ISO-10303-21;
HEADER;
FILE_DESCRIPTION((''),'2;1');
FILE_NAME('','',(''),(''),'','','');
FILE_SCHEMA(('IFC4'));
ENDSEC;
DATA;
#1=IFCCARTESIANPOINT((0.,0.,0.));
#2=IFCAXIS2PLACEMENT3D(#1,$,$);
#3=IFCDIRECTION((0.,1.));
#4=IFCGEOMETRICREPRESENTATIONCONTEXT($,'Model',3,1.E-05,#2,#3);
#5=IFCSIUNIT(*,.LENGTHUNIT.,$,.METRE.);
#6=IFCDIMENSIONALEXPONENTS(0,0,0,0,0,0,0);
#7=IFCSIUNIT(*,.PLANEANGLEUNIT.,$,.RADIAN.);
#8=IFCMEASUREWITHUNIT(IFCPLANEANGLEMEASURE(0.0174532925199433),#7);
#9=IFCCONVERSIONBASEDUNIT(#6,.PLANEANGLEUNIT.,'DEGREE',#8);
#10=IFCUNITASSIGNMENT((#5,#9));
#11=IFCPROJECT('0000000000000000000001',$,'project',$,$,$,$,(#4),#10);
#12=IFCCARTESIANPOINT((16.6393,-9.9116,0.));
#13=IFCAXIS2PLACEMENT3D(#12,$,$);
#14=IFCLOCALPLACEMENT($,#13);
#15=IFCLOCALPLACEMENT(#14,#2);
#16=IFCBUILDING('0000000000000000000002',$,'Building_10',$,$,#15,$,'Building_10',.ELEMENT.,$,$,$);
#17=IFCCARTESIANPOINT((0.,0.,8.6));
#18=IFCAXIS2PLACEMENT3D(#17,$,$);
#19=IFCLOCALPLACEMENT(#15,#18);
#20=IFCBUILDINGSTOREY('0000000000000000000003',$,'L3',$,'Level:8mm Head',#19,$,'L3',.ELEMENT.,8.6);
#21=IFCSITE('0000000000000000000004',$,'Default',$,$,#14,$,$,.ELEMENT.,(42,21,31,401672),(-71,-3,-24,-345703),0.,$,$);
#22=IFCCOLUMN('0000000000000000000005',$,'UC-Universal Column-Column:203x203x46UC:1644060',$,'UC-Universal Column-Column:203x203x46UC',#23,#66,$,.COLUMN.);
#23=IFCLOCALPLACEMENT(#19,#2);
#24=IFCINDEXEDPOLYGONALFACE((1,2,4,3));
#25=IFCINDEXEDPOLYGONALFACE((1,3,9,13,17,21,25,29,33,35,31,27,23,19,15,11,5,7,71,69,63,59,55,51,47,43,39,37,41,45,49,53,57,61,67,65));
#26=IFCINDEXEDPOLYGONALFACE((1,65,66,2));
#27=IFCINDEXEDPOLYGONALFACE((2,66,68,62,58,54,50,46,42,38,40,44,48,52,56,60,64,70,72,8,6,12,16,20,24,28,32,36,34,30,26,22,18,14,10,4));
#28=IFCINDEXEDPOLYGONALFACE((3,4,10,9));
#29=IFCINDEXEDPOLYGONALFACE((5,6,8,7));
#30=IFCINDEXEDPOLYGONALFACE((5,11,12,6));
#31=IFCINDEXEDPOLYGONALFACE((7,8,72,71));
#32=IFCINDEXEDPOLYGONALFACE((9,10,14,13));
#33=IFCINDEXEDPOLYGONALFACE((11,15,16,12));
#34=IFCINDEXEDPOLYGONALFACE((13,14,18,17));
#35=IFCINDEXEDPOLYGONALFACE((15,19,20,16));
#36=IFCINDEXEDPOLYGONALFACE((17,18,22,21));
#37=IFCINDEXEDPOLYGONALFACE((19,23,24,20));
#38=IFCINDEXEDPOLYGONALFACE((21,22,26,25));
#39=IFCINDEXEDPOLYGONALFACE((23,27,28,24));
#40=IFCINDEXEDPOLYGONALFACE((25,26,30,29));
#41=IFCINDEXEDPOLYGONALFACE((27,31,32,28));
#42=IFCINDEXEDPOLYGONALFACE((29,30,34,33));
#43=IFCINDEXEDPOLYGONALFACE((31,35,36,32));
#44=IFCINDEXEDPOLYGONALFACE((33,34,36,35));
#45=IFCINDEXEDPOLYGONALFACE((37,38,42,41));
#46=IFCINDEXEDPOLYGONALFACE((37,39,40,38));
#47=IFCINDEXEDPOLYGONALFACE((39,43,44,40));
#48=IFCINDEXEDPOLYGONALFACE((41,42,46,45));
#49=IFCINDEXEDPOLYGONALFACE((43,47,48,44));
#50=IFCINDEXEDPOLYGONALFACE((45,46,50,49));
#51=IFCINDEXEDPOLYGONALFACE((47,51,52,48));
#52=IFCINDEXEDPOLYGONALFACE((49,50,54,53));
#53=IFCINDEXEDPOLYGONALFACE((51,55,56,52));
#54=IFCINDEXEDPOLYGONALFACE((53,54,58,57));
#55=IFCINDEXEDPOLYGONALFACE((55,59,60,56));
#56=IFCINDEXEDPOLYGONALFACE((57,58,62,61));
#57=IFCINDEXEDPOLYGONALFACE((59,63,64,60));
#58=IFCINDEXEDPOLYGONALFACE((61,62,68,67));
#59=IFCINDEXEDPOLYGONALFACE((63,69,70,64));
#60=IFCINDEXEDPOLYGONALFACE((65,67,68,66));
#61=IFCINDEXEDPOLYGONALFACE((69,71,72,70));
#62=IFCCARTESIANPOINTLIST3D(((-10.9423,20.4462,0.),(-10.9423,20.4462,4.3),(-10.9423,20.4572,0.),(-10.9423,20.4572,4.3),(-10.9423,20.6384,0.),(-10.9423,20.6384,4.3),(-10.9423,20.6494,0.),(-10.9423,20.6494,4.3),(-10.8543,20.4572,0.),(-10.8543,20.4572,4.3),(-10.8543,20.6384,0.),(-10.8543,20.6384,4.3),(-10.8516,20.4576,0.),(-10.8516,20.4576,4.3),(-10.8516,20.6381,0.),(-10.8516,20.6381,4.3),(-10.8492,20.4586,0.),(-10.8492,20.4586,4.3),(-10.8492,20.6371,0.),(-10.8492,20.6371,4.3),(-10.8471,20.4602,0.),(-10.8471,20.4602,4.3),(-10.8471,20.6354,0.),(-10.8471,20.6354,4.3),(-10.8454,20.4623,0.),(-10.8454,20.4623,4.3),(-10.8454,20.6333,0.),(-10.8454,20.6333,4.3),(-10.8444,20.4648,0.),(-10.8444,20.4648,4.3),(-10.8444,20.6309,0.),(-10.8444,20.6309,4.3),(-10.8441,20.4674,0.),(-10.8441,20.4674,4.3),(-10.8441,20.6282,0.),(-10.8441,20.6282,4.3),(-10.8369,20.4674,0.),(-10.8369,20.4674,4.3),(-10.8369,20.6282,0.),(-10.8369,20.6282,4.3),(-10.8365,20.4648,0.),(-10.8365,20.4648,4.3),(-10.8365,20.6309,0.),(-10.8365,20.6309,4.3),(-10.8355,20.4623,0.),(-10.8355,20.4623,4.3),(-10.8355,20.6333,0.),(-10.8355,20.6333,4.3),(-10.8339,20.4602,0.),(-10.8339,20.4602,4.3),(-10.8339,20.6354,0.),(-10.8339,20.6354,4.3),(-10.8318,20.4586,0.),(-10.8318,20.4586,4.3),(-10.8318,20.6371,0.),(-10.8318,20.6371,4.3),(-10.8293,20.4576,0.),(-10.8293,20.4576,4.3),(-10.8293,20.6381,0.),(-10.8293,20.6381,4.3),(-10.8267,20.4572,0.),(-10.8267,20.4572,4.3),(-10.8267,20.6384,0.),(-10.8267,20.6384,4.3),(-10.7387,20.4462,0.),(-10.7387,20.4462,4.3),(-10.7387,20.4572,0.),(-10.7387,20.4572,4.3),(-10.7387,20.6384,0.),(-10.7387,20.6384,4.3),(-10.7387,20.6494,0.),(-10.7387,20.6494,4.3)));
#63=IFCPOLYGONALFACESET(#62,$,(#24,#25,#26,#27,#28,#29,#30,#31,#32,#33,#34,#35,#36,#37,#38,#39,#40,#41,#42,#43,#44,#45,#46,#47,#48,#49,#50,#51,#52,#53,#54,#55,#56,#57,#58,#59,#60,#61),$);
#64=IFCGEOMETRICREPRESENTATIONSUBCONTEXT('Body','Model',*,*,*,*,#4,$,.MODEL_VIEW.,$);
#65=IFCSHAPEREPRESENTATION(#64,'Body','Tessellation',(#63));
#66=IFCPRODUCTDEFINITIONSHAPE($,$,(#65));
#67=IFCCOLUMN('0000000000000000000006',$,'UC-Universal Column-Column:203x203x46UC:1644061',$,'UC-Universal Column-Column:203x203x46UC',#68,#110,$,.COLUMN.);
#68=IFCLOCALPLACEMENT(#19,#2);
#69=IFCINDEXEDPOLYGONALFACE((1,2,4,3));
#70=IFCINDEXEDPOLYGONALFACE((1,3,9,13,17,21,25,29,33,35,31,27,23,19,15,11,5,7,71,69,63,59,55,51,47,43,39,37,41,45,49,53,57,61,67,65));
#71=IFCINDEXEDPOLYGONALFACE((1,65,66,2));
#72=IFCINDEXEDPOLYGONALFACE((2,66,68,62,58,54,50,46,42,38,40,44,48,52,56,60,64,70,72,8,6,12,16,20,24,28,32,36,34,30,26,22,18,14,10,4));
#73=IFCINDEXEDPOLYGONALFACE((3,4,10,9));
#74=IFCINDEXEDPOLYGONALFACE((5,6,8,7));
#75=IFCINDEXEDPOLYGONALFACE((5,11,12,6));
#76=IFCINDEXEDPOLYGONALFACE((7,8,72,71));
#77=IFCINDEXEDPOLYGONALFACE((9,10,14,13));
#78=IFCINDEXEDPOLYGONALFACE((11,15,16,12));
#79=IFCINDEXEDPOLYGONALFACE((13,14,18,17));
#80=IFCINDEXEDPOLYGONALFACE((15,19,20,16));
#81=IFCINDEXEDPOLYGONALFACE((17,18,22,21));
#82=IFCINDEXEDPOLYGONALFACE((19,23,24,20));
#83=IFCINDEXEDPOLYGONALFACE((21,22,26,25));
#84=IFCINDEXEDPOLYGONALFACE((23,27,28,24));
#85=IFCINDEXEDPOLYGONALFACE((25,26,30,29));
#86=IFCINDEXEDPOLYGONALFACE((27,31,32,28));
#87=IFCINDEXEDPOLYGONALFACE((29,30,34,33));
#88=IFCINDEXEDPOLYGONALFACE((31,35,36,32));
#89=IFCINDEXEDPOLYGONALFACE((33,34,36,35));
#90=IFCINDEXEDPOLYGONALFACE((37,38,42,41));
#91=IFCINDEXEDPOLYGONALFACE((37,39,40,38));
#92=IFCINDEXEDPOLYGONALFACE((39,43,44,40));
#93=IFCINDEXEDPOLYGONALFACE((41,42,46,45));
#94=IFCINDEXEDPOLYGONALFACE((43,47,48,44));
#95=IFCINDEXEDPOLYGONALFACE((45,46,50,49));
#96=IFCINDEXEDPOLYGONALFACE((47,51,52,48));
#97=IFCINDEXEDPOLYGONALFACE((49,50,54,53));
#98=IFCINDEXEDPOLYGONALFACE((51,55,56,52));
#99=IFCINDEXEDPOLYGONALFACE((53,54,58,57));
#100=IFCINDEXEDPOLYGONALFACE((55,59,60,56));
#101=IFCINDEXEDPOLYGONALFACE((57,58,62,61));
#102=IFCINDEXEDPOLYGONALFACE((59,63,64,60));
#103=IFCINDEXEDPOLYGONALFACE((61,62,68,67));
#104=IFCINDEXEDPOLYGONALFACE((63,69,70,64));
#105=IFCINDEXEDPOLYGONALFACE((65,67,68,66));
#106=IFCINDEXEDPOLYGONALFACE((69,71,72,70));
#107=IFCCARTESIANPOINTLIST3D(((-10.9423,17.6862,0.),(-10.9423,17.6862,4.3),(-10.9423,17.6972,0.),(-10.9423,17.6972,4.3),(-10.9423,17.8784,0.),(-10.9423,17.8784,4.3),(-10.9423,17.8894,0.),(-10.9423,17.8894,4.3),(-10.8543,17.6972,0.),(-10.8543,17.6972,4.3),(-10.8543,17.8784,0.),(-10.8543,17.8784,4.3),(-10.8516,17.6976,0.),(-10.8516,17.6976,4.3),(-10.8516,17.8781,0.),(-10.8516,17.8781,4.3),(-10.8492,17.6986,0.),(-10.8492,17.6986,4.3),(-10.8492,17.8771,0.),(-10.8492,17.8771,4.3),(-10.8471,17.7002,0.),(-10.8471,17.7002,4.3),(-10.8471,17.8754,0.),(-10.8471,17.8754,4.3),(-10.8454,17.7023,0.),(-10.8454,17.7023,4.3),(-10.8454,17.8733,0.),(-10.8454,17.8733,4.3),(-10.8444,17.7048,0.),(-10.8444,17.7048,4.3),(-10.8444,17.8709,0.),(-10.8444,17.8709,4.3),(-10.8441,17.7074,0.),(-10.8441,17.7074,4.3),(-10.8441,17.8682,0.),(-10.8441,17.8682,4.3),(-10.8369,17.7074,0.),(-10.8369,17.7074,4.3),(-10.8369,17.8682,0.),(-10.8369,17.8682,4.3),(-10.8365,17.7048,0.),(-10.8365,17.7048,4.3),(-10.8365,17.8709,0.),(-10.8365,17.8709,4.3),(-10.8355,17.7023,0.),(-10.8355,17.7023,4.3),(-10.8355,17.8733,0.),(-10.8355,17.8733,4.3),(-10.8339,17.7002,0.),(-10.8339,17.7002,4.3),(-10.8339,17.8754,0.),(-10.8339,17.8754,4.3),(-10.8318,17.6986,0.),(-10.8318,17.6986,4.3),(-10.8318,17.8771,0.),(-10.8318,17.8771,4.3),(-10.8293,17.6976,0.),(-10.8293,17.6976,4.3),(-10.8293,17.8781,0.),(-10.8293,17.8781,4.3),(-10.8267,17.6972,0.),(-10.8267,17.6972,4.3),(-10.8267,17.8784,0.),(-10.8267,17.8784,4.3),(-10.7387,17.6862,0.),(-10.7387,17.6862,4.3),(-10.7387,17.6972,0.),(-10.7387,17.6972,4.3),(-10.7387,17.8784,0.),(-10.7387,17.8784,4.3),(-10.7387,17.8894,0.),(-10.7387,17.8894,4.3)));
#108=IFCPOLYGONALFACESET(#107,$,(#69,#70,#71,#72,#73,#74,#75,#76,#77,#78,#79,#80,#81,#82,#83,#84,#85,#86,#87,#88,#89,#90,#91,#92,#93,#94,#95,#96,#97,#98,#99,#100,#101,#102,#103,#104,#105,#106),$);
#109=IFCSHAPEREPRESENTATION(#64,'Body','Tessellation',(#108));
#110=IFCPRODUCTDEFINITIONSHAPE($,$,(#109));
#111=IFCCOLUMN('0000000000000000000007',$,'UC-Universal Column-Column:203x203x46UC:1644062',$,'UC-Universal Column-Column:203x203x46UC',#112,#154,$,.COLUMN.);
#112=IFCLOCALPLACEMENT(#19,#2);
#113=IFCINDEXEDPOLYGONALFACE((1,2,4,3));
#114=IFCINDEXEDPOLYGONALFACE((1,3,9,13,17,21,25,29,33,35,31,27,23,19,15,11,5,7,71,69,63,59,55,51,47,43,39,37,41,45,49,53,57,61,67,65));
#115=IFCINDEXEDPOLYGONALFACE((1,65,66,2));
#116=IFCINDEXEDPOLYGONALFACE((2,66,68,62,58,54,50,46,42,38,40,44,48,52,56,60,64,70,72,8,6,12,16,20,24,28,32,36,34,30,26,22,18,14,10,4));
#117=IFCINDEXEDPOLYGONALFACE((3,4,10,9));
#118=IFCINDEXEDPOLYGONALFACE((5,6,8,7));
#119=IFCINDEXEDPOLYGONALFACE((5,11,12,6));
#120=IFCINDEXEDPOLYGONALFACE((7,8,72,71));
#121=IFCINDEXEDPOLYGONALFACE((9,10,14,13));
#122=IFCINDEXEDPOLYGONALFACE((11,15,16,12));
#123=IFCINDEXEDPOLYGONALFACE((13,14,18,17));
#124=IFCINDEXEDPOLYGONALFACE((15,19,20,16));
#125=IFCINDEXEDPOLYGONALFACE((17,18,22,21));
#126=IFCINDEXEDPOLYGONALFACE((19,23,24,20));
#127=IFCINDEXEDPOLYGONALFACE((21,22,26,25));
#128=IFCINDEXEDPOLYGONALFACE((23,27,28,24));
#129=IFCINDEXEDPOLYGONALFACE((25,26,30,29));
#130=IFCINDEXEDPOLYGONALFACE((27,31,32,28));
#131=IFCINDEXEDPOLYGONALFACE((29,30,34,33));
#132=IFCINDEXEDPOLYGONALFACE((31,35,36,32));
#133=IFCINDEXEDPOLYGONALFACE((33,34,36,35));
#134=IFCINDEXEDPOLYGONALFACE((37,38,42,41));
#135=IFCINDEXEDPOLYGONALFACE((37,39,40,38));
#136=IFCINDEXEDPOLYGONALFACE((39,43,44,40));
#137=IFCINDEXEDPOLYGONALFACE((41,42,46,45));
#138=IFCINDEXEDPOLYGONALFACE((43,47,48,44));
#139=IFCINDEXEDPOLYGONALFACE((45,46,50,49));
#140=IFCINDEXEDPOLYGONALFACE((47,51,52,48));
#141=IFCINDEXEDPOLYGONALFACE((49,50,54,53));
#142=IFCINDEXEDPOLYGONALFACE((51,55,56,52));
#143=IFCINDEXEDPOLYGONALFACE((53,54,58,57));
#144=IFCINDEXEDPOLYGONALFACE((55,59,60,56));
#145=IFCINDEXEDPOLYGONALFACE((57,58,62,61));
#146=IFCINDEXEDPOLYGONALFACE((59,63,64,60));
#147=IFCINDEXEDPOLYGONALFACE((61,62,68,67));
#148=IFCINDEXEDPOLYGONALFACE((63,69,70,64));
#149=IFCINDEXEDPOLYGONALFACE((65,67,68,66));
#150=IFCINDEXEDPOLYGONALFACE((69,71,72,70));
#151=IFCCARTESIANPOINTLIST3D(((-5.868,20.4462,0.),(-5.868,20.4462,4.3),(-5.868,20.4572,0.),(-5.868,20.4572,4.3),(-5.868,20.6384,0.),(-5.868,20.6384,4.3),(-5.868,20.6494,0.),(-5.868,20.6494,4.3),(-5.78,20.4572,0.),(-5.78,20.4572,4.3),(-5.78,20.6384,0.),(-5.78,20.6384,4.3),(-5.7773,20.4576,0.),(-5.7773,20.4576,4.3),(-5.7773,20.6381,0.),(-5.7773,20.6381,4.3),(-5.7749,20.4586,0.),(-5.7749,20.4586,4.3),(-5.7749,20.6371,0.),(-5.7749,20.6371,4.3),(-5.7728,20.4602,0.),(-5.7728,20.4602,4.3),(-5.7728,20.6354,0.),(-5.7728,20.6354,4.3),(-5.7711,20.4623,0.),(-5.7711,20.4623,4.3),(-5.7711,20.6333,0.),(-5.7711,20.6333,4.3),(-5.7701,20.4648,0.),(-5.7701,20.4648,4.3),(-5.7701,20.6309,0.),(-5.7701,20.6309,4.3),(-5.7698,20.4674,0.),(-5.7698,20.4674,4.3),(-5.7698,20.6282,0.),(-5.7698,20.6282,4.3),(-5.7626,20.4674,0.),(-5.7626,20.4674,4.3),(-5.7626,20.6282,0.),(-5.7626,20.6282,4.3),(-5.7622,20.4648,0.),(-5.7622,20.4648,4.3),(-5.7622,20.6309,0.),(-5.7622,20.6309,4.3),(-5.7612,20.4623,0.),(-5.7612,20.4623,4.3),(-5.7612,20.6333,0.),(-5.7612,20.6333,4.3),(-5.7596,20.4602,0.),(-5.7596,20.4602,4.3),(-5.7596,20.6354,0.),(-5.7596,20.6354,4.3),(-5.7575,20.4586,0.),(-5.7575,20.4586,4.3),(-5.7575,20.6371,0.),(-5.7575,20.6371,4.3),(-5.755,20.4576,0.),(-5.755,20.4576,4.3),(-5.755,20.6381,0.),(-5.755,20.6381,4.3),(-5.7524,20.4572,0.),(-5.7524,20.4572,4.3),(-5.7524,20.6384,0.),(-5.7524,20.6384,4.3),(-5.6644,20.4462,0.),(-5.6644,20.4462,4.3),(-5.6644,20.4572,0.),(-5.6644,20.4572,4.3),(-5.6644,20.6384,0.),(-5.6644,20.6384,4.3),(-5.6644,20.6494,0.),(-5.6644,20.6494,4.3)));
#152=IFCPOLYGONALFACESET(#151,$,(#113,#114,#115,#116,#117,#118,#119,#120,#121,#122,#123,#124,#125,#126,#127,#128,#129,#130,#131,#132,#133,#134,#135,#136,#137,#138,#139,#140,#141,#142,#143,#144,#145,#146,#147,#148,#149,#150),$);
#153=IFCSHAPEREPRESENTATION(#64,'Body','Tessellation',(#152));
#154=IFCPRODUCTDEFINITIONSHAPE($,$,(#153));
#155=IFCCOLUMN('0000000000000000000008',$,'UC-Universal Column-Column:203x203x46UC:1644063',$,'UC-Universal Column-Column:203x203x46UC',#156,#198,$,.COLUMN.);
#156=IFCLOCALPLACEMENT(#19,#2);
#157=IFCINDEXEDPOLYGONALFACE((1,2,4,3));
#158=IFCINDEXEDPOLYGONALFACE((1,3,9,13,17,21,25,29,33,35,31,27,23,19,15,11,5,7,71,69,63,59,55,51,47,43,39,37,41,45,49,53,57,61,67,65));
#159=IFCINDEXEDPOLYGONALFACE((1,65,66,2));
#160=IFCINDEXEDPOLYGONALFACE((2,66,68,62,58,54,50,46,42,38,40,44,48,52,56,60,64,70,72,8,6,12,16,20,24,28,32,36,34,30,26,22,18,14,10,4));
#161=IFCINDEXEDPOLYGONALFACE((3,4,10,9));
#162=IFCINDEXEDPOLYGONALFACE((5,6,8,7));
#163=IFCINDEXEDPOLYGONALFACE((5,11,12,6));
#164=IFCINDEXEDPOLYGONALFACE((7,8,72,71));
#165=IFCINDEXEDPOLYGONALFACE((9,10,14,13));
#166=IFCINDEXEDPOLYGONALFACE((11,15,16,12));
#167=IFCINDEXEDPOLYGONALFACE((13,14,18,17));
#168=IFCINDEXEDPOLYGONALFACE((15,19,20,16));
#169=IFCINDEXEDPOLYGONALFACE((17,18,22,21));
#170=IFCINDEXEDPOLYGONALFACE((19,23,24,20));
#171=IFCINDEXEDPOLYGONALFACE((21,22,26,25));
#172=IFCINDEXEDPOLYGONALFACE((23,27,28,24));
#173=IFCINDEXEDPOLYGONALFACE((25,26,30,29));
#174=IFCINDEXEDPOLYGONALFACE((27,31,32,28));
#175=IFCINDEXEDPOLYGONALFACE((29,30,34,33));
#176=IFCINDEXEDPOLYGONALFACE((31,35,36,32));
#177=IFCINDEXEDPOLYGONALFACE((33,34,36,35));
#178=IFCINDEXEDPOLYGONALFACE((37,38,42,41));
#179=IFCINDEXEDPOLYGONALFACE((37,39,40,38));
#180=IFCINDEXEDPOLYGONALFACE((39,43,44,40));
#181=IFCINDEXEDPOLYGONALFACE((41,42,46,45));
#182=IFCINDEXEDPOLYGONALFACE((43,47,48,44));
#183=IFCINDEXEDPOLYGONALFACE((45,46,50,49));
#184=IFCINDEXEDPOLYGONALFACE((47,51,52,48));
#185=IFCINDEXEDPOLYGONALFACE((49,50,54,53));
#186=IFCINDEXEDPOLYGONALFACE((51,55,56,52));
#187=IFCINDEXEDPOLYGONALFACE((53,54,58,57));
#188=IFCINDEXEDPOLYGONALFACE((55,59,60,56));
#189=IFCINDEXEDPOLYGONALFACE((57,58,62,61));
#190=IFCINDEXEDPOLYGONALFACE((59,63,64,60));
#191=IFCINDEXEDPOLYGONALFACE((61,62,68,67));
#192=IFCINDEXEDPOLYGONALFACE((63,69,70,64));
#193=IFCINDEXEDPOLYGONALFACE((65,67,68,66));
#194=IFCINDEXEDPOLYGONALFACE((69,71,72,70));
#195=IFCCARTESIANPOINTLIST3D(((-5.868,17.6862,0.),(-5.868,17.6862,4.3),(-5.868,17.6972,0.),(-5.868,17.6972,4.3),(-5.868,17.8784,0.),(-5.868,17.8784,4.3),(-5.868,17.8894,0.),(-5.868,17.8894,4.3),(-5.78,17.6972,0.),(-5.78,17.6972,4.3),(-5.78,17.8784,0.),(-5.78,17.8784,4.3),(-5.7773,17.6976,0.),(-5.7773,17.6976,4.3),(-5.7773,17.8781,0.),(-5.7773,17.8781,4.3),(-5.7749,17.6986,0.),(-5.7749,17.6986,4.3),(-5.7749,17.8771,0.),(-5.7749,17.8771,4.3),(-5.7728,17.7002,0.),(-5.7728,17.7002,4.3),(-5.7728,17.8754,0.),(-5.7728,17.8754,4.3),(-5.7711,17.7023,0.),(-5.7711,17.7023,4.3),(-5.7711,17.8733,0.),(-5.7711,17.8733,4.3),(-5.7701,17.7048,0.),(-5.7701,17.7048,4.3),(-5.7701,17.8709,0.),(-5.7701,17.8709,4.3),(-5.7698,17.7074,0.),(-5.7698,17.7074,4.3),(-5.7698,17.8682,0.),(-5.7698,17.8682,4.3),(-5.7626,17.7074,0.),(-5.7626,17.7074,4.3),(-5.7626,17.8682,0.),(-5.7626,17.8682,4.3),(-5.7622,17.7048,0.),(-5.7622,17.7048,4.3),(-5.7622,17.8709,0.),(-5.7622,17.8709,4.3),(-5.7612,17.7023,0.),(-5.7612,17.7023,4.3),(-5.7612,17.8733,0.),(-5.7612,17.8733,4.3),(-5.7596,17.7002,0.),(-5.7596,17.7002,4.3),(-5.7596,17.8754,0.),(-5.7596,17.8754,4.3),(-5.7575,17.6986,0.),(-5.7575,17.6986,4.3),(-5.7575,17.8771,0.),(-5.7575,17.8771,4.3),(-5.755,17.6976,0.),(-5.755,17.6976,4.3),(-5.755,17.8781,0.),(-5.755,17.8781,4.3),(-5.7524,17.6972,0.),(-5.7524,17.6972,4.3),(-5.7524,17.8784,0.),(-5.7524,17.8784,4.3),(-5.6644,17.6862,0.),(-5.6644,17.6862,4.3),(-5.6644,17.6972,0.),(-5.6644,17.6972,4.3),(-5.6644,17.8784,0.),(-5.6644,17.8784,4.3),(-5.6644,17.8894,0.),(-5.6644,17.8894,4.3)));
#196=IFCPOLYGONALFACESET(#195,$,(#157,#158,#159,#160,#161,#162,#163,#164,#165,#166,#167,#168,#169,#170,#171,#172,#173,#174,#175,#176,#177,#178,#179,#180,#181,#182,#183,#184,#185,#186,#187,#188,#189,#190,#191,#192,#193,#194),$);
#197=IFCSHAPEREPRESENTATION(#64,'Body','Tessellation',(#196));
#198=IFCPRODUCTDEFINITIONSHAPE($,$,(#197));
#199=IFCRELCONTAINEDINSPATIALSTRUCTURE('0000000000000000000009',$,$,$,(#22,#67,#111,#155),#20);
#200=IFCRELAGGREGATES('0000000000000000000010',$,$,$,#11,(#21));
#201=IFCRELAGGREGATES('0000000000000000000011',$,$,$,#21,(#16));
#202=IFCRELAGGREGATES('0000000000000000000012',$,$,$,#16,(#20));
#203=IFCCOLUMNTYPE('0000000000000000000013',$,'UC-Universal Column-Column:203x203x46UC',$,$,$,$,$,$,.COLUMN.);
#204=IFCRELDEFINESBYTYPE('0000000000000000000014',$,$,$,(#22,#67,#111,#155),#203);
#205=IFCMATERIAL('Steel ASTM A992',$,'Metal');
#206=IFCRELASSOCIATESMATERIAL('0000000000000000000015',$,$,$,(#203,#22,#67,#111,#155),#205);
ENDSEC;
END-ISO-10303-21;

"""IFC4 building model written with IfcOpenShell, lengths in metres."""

from ifc_helpers import new_model, entity, si_unit, converted_unit, direction, frame, origin, place, context, subcontext, project, spatial, line, arc, indexed_curve, outline, extrude, source, transform, mapped, material, type_object, type_shapes, element, save


model = new_model("IFC4")

# Units and contexts
model_context = context("Model", 3, precision=1e-05, world=origin(), true_north=direction((0.0, 1.0)))
body_context = subcontext(model_context, "Body", "Model", "MODEL_VIEW")
ifc_project = project(units=[si_unit("LENGTHUNIT", "METRE"), converted_unit("PLANEANGLEUNIT", "DEGREE", entity("IfcPlaneAngleMeasure", 0.0174532925199433), si_unit("PLANEANGLEUNIT", "RADIAN"), dimensions=[0, 0, 0, 0, 0, 0, 0])], contexts=[model_context])

# Site, building, storey
site_placement = place(None, frame((16.6393, -9.9116, 0.0)))
site = spatial("IfcSite", under=ifc_project, at=site_placement, Name="Default", CompositionType="ELEMENT", RefLatitude=(42, 21, 31, 401672), RefLongitude=(-71, -3, -24, -345703), RefElevation=0.0)
building_placement = place(site_placement, origin())
building = spatial("IfcBuilding", under=site, at=building_placement, Name="Building_10", LongName="Building_10", CompositionType="ELEMENT")
storey_placement = place(building_placement, frame((0.0, 0.0, 8.6)))
storey = spatial("IfcBuildingStorey", under=building, at=storey_placement, Name="L3", ObjectType="Level:8mm Head", LongName="L3", CompositionType="ELEMENT", Elevation=8.6)

# Columns
ifc_material_1 = material(Name="Steel ASTM A992", Category="Metal")
column_type = type_object("IfcColumnType", Name="UC-Universal Column-Column:203x203x46UC", PredefinedType="COLUMN", material=ifc_material_1)
shared_shape_1 = source(origin(), body_context, "Body", "SweptSolid", [
    extrude(outline(indexed_curve([(-0.1018, -0.1016), (0.1018, -0.1016), (0.1018, -0.0906), (0.0138, -0.0906), (0.0066, -0.0876), (0.0036, -0.0804), (0.0036, 0.0804), (0.0066, 0.0876), (0.0138, 0.0906), (0.1018, 0.0906), (0.1018, 0.1016), (-0.1018, 0.1016), (-0.1018, 0.0906), (-0.0138, 0.0906), (-0.0066, 0.0876), (-0.0036, 0.0804), (-0.0036, -0.0804), (-0.0066, -0.0876), (-0.0138, -0.0906), (-0.1018, -0.0906)], segments=[line(1, 2, 3, 4), arc(4, 5, 6), line(6, 7), arc(7, 8, 9), line(9, 10, 11, 12, 13, 14), arc(14, 15, 16), line(16, 17), arc(17, 18, 19), line(19, 20, 1)], self_intersect=False)), frame((0.0, 0.0, 8.6), z_axis=(0.0, 0.0, 1.0), x_axis=(-1.0, 0.0, 0.0)), (0.0, 0.0, 1.0), 4.3),
])
type_shapes(column_type, [shared_shape_1])
for number, where, name in (
    (1, (-10.8405, 20.5478, -8.6), "UC-Universal Column-Column:203x203x46UC:1644060"),
    (2, (-10.8405, 17.7878, -8.6), "UC-Universal Column-Column:203x203x46UC:1644061"),
    (3, (-5.7662, 20.5478, -8.6), "UC-Universal Column-Column:203x203x46UC:1644062"),
    (4, (-5.7662, 17.7878, -8.6), "UC-Universal Column-Column:203x203x46UC:1644063"),
):
    element("IfcColumn", number, at=place(storey_placement, frame(where)), inside=storey, type_object=column_type, material=ifc_material_1, Name=name, ObjectType="UC-Universal Column-Column:203x203x46UC", PredefinedType="COLUMN", context=body_context, shape_type="MappedRepresentation", body=[
        mapped(shared_shape_1, transform((0.0, 0.0, 0.0), scale=1.0)),
    ])

save(model, "model.ifc")
